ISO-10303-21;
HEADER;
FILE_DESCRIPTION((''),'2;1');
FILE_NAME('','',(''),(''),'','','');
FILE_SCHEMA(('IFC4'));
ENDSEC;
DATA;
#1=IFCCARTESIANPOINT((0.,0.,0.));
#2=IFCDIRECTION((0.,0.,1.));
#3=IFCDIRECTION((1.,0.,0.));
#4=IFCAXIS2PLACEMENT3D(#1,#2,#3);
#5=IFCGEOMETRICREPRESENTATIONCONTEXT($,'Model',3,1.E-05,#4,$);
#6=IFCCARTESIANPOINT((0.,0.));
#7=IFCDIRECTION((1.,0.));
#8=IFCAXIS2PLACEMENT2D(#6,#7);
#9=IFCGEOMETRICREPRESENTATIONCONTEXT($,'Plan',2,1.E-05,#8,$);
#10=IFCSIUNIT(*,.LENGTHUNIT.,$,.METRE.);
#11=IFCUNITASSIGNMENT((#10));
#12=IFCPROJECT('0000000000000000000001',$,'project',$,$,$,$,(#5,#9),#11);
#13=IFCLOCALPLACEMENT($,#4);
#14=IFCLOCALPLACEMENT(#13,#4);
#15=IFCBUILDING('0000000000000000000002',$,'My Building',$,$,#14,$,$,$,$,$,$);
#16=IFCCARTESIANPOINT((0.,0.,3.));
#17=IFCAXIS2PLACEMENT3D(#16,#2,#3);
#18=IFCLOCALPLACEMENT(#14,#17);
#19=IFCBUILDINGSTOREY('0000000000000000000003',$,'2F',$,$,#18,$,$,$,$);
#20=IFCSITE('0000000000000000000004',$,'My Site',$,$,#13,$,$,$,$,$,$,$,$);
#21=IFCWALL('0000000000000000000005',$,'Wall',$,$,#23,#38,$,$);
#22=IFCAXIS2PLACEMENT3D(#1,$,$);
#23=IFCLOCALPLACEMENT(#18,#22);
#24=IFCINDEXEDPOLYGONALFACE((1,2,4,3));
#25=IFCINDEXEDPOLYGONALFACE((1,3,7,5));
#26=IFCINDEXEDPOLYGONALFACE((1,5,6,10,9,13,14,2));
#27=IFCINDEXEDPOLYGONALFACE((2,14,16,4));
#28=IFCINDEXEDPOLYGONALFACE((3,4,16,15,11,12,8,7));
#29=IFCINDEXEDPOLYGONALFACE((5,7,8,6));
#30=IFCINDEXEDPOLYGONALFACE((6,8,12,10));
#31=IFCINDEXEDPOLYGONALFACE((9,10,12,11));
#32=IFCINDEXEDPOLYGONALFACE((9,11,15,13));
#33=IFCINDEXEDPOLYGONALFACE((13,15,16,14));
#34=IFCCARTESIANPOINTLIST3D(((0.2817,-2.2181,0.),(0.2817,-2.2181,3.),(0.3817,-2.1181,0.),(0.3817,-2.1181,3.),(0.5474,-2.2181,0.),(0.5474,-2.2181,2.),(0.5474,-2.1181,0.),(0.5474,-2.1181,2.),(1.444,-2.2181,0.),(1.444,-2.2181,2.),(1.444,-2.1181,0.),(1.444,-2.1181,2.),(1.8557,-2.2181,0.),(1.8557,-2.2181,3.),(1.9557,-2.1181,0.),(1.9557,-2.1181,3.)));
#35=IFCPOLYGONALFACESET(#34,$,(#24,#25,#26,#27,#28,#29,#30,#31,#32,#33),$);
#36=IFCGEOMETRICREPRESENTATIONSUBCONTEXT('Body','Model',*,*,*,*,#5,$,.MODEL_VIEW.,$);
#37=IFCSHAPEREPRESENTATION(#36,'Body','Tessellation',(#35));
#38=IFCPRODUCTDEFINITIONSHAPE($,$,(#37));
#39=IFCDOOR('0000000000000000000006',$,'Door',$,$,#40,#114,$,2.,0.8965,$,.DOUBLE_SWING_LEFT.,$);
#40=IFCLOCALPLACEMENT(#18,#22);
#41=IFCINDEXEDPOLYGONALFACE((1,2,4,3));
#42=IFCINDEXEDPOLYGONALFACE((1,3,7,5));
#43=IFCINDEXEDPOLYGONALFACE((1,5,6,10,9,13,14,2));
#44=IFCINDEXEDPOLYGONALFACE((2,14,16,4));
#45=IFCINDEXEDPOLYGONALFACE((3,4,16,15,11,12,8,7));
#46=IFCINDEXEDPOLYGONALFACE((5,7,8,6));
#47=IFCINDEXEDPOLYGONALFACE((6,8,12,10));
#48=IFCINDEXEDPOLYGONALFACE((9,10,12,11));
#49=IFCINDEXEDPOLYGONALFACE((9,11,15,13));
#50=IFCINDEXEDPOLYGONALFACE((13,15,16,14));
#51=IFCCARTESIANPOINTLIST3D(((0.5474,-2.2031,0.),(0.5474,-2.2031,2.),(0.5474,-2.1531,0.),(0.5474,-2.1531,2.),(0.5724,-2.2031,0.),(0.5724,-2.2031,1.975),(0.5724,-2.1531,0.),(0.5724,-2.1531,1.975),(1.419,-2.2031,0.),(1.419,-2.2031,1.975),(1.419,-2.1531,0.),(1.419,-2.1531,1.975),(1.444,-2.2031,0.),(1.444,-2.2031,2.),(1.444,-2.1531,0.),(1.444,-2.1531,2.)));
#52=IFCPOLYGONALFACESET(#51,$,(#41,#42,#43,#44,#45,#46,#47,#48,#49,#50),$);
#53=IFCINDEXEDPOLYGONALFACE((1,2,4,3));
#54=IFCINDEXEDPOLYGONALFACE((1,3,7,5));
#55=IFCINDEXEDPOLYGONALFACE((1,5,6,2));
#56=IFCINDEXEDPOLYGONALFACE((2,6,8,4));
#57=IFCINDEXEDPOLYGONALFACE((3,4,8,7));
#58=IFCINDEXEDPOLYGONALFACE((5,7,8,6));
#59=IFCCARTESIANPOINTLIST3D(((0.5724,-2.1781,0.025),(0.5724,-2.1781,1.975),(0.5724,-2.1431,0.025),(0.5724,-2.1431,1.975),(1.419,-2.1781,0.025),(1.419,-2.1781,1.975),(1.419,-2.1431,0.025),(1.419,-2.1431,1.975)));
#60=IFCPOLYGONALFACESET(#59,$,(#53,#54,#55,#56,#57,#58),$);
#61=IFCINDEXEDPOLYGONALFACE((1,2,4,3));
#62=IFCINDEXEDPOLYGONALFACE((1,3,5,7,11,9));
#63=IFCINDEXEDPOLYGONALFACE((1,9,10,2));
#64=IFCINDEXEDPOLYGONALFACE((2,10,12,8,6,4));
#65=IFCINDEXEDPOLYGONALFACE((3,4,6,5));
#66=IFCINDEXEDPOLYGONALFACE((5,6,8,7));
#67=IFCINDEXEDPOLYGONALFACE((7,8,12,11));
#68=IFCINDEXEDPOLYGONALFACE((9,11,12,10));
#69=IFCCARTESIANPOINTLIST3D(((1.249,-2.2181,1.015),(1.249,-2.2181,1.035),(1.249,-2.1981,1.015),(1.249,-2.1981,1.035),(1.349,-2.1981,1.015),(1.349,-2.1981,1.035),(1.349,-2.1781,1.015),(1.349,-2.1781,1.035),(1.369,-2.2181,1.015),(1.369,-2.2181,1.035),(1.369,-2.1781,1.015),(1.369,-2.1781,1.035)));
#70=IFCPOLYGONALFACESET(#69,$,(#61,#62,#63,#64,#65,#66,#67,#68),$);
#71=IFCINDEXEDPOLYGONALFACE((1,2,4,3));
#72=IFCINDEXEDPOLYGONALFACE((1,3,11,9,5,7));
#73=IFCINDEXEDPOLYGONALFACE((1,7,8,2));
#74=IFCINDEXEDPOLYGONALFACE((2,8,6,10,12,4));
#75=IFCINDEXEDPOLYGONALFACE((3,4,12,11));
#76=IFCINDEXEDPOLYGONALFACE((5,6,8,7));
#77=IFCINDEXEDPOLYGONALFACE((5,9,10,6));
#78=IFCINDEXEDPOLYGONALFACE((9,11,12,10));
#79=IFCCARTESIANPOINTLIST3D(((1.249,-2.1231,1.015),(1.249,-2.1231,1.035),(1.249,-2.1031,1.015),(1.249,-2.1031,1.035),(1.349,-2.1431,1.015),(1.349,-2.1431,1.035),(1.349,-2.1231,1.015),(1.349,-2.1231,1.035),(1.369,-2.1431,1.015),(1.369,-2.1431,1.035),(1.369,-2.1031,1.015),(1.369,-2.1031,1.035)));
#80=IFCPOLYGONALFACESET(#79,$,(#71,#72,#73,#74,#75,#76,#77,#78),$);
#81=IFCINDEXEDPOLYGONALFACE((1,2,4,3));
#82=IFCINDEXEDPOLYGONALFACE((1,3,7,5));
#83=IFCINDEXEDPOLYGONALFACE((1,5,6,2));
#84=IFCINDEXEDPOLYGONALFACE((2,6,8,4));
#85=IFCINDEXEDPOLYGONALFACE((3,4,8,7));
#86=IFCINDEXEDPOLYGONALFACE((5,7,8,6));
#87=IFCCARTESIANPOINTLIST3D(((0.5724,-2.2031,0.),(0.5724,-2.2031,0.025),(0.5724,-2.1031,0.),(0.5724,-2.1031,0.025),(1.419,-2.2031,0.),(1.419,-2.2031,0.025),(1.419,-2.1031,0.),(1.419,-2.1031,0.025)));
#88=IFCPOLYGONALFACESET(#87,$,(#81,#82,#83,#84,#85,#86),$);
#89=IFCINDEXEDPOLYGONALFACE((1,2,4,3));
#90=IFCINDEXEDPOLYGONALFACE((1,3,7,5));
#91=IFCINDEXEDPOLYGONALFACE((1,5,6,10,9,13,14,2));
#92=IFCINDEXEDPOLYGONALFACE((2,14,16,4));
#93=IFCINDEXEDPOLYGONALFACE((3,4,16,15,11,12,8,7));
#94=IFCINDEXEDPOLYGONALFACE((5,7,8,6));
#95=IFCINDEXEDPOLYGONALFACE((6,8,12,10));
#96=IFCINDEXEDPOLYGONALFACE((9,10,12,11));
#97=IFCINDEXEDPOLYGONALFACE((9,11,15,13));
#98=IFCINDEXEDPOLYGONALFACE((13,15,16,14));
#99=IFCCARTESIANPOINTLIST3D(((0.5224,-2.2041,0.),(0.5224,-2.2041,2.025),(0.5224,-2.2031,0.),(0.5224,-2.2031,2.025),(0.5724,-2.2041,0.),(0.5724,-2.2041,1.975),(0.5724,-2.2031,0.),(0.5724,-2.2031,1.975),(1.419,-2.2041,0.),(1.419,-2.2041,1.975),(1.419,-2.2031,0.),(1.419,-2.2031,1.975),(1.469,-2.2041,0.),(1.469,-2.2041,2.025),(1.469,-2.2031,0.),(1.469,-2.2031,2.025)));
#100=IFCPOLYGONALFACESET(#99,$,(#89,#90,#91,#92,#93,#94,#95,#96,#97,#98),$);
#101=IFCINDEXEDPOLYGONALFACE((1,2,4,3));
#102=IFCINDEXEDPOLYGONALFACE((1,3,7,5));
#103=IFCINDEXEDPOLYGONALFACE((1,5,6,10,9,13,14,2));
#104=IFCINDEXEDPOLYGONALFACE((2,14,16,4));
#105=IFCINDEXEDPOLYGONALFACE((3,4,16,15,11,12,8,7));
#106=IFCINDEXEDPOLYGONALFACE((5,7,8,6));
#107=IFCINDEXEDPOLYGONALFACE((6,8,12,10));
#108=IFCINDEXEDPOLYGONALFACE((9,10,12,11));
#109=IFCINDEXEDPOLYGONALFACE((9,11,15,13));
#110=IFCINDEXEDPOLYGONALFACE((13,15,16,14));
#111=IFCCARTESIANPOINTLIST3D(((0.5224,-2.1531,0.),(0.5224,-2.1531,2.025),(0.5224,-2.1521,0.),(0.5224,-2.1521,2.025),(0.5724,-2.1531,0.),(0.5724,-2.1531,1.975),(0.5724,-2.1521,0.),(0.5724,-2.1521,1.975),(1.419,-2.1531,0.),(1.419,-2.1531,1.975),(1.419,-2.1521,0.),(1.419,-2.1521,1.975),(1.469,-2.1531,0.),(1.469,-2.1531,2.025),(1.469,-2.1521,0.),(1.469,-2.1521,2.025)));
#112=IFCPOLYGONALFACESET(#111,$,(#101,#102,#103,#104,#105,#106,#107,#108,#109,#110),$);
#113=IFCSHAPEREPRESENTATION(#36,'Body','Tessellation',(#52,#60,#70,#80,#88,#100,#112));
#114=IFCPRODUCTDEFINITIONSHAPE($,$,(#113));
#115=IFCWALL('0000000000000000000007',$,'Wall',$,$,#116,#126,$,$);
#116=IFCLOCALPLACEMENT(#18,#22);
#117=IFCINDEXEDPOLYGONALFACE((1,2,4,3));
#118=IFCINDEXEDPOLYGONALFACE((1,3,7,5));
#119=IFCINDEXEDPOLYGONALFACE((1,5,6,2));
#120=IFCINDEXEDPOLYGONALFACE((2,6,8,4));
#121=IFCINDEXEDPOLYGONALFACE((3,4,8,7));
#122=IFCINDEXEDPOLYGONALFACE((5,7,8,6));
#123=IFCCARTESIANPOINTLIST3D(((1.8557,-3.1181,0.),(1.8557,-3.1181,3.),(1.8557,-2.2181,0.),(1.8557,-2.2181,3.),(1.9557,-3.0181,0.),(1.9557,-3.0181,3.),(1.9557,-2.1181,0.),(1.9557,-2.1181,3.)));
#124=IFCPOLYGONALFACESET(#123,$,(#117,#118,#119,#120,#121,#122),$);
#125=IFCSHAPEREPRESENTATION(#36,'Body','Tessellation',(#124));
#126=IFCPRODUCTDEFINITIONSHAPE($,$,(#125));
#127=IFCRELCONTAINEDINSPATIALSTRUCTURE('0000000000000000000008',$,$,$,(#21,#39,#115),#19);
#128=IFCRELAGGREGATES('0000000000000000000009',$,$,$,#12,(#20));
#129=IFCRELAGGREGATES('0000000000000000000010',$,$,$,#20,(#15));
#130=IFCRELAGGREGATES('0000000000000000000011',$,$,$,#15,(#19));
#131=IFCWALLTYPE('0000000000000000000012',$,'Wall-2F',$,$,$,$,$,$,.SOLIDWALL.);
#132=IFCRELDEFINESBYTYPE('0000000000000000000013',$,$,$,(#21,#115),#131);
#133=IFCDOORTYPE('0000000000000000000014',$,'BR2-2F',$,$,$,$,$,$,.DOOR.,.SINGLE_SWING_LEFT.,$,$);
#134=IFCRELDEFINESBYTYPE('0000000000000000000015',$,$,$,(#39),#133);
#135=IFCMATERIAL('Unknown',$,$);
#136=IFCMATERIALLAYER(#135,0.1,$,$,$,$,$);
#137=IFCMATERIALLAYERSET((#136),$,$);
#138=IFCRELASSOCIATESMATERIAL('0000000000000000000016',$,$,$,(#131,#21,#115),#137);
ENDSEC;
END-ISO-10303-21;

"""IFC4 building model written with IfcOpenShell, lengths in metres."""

from ifc_helpers import new_model, entity, si_unit, frame, origin_with_axes, origin_2d_with_axis, place, context, subcontext, project, spatial, line, indexed_curve, outline, extrude, shape, source, transform, mapped, material, layer, layer_set, layer_usage, type_object, type_shapes, element, fill, save


model = new_model("IFC4")

# Units and contexts
model_context = context("Model", 3, precision=1e-05, world=origin_with_axes())
plan_context = context("Plan", 2, precision=1e-05, world=origin_2d_with_axis())
body_context_1 = subcontext(model_context, "Body", "Model", "MODEL_VIEW")
body_context_2 = subcontext(plan_context, "Body", "Plan", "PLAN_VIEW")
ifc_project = project(units=[si_unit("LENGTHUNIT", "METRE")], contexts=[model_context, plan_context])

# Site, building, storey
site_placement = place(None, origin_with_axes())
site = spatial("IfcSite", under=ifc_project, at=site_placement, Name="My Site")
building_placement = place(site_placement, origin_with_axes())
building = spatial("IfcBuilding", under=site, at=building_placement, Name="My Building")
storey_placement = place(building_placement, frame((0.0, 0.0, 3.0), z_axis=(0.0, 0.0, 1.0), x_axis=(1.0, 0.0, 0.0)))
storey = spatial("IfcBuildingStorey", under=building, at=storey_placement, Name="2F")

# Shared definitions
ifc_material = material(Name="Unknown")

# Shared definitions
shared_shape_1 = source(origin_with_axes(), body_context_1, "Body", "SweptSolid", [
    extrude(outline(indexed_curve([(0.0, 0.0), (0.8965, 0.0), (0.8965, 2.0), (0.0, 2.0)], segments=[line(1, 2, 3, 4, 1)])), frame((0.0, -0.6, 0.0), z_axis=(0.0, -1.0, 0.0), x_axis=(1.0, 0.0, 0.0)), (0.0, 0.0, -1.0), 1.2),
])
door_type_1 = type_object("IfcDoorType", Name="BR2-2F", OperationType="SINGLE_SWING_LEFT", PredefinedType="DOOR")
shared_shape_2 = source(origin_with_axes(), body_context_1, "Body", "SweptSolid", [
    extrude(outline(indexed_curve([(0.0, 0.0), (0.0, 2.0), (0.8965, 2.0), (0.8965, 0.0), (0.8715, 0.0), (0.8715, 1.975), (0.025, 1.975), (0.025, 0.0)], segments=[line(1, 2, 3, 4, 5, 6, 7, 8, 1)])), frame((0.0, 0.0, 0.0), z_axis=(0.0, -1.0, 0.0), x_axis=(1.0, 0.0, 0.0)), (0.0, 0.0, -1.0), 0.05),
    extrude(outline(indexed_curve([(0.0, 0.0), (0.8465, 0.0), (0.8465, 0.035), (0.0, 0.035)], segments=[line(1, 2, 3, 4, 1)])), frame((0.025, 0.025, 0.025), z_axis=(0.0, 0.0, 1.0), x_axis=(1.0, 0.0, 0.0)), (0.0, 0.0, 1.0), 1.95),
    extrude(outline(indexed_curve([(0.0, 0.0), (0.0, -0.04), (-0.12, -0.04), (-0.12, -0.02), (-0.02, -0.02), (-0.02, 0.0)], segments=[line(1, 2, 3, 4, 5, 6, 1)])), frame((0.8215, 0.025, 1.015), z_axis=(0.0, 0.0, 1.0), x_axis=(1.0, 0.0, 0.0)), (0.0, 0.0, 1.0), 0.02),
    extrude(outline(indexed_curve([(0.0, 0.0), (0.0, 0.04), (-0.12, 0.04), (-0.12, 0.02), (-0.02, 0.02), (-0.02, 0.0)], segments=[line(1, 2, 3, 4, 5, 6, 1)])), frame((0.8215, 0.06, 1.015), z_axis=(0.0, 0.0, 1.0), x_axis=(1.0, 0.0, 0.0)), (0.0, 0.0, 1.0), 0.02),
    extrude(outline(indexed_curve([(0.0, 0.0), (0.8465, 0.0), (0.8465, 0.1), (0.0, 0.1)], segments=[line(1, 2, 3, 4, 1)])), frame((0.025, 0.0, 0.0), z_axis=(0.0, 0.0, 1.0), x_axis=(1.0, 0.0, 0.0)), (0.0, 0.0, 1.0), 0.025),
    extrude(outline(indexed_curve([(0.0, 0.0), (0.0, 2.025), (0.9465, 2.025), (0.9465, 0.0), (0.8965, 0.0), (0.8965, 1.975), (0.05, 1.975), (0.05, 0.0)], segments=[line(1, 2, 3, 4, 5, 6, 7, 8, 1)])), frame((-0.025, -0.001, 0.0), z_axis=(0.0, -1.0, 0.0), x_axis=(1.0, 0.0, 0.0)), (0.0, 0.0, -1.0), 0.001),
    extrude(outline(indexed_curve([(0.0, 0.0), (0.0, 2.025), (0.9465, 2.025), (0.9465, 0.0), (0.8965, 0.0), (0.8965, 1.975), (0.05, 1.975), (0.05, 0.0)], segments=[line(1, 2, 3, 4, 5, 6, 7, 8, 1)])), frame((-0.025, 0.05, 0.0), z_axis=(0.0, -1.0, 0.0), x_axis=(1.0, 0.0, 0.0)), (0.0, 0.0, -1.0), 0.001),
])
shared_shape_3 = source(origin_with_axes(), body_context_2, "Body", "Curve2D", [
    entity("IfcIndexedPolyCurve", entity("IfcCartesianPointList2D", [[0.0, 0.0], [0.025, 0.0], [0.025, 0.05], [0.0, 0.05]]), [entity("IfcLineIndex", [1, 2, 3, 4, 1])]),
    entity("IfcIndexedPolyCurve", entity("IfcCartesianPointList2D", [[0.8965, 0.0], [0.8715, 0.0], [0.8715, 0.05], [0.8965, 0.05]]), [entity("IfcLineIndex", [1, 2, 3, 4, 1])]),
    entity("IfcIndexedPolyCurve", entity("IfcCartesianPointList2D", [[0.025, 0.05], [0.025, -0.7965], [0.06, -0.7965]])),
    entity("IfcTrimmedCurve", entity("IfcEllipse", entity("IfcAxis2Placement2D", entity("IfcCartesianPoint", [0.06, 0.05]), entity("IfcDirection", [1.0, 0.0])), 0.8115, 0.8465), [entity("IfcCartesianPoint", [0.06, -0.7965])], [entity("IfcCartesianPoint", [0.06, 0.8965])], True, "CARTESIAN"),
    entity("IfcIndexedPolyCurve", entity("IfcCartesianPointList2D", [[0.025, 0.05], [0.06, 0.05], [0.06, 0.8965], [0.025, 0.8965]]), [entity("IfcLineIndex", [1, 2, 3, 4, 1])]),
])
type_shapes(door_type_1, [shared_shape_2, shared_shape_3])

# Shared definitions
ifc_layer_1 = layer(ifc_material, 0.1)
ifc_layer_set_1 = layer_set([ifc_layer_1])
wall_type_1 = type_object("IfcWallType", Name="Wall-2F", PredefinedType="SOLIDWALL", material=ifc_layer_set_1)

# Wall, opening, door
ifc_layer_usage_1 = layer_usage(ifc_layer_set_1, "AXIS2", "POSITIVE", 0.0)
wall_1_placement = place(storey_placement, frame((0.2817, -2.2181, 0.0), z_axis=(0.0, 0.0, 1.0), x_axis=(1.0, 0.0, 0.0)))
wall_1 = element("IfcWall", 1, at=wall_1_placement, inside=storey, type_object=wall_type_1, material=ifc_layer_usage_1, Name="Wall", context=body_context_1, shape_type="SweptSolid", body=[
    extrude(outline(indexed_curve([(0.0, 0.0), (0.1, 0.1), (1.674, 0.1), (1.574, 0.0)], segments=[line(1, 2, 3, 4, 1)])), origin_with_axes(), (0.0, 0.0, 1.0), 3.0),
])
opening_1_placement = place(wall_1_placement, frame((0.2657, 0.015, 0.0), z_axis=(0.0, 0.0, 1.0), x_axis=(1.0, 0.0, 0.0)))
opening_1 = element("IfcOpeningElement", 2, at=opening_1_placement, cuts=wall_1, PredefinedType="OPENING", context=body_context_1, shape_type="MappedRepresentation", body=[
    mapped(shared_shape_1, transform((0.0, 0.0, 0.0), x_axis=(1.0, 0.0, 0.0), y_axis=(0.0, 1.0, 0.0), z_axis=(0.0, 0.0, 1.0), scale=1.0)),
])
door_1_placement = place(opening_1_placement, origin_with_axes())
door_1 = element("IfcDoor", 3, at=door_1_placement, inside=storey, type_object=door_type_1, Name="Door", OperationType="DOUBLE_SWING_LEFT", OverallHeight=2.0, OverallWidth=0.8965, shapes=[
    shape(body_context_1, "Body", "MappedRepresentation", [mapped(shared_shape_2, transform((0.0, 0.0, 0.0), x_axis=(1.0, 0.0, 0.0), y_axis=(0.0, 1.0, 0.0), z_axis=(0.0, 0.0, 1.0), scale=1.0))]),
    shape(body_context_2, "Body", "MappedRepresentation", [mapped(shared_shape_3, transform((0.0, 0.0, 0.0), x_axis=(1.0, 0.0, 0.0), y_axis=(0.0, 1.0, 0.0), z_axis=(0.0, 0.0, 1.0), scale=1.0))]),
])
fill(opening_1, door_1)

# Wall
ifc_layer_usage_2 = layer_usage(ifc_layer_set_1, "AXIS2", "POSITIVE", 0.0)
wall_2_placement = place(storey_placement, frame((1.8557, -2.2181, 0.0), z_axis=(0.0, 0.0, 1.0), x_axis=(0.0, -1.0, 0.0)))
element("IfcWall", 4, at=wall_2_placement, inside=storey, type_object=wall_type_1, material=ifc_layer_usage_2, Name="Wall", context=body_context_1, shape_type="SweptSolid", body=[
    extrude(outline(indexed_curve([(0.0, 0.0), (-0.1, 0.1), (0.8, 0.1), (0.9, 0.0)], segments=[line(1, 2, 3, 4, 1)])), origin_with_axes(), (0.0, 0.0, 1.0), 3.0),
])

save(model, "model.ifc")
